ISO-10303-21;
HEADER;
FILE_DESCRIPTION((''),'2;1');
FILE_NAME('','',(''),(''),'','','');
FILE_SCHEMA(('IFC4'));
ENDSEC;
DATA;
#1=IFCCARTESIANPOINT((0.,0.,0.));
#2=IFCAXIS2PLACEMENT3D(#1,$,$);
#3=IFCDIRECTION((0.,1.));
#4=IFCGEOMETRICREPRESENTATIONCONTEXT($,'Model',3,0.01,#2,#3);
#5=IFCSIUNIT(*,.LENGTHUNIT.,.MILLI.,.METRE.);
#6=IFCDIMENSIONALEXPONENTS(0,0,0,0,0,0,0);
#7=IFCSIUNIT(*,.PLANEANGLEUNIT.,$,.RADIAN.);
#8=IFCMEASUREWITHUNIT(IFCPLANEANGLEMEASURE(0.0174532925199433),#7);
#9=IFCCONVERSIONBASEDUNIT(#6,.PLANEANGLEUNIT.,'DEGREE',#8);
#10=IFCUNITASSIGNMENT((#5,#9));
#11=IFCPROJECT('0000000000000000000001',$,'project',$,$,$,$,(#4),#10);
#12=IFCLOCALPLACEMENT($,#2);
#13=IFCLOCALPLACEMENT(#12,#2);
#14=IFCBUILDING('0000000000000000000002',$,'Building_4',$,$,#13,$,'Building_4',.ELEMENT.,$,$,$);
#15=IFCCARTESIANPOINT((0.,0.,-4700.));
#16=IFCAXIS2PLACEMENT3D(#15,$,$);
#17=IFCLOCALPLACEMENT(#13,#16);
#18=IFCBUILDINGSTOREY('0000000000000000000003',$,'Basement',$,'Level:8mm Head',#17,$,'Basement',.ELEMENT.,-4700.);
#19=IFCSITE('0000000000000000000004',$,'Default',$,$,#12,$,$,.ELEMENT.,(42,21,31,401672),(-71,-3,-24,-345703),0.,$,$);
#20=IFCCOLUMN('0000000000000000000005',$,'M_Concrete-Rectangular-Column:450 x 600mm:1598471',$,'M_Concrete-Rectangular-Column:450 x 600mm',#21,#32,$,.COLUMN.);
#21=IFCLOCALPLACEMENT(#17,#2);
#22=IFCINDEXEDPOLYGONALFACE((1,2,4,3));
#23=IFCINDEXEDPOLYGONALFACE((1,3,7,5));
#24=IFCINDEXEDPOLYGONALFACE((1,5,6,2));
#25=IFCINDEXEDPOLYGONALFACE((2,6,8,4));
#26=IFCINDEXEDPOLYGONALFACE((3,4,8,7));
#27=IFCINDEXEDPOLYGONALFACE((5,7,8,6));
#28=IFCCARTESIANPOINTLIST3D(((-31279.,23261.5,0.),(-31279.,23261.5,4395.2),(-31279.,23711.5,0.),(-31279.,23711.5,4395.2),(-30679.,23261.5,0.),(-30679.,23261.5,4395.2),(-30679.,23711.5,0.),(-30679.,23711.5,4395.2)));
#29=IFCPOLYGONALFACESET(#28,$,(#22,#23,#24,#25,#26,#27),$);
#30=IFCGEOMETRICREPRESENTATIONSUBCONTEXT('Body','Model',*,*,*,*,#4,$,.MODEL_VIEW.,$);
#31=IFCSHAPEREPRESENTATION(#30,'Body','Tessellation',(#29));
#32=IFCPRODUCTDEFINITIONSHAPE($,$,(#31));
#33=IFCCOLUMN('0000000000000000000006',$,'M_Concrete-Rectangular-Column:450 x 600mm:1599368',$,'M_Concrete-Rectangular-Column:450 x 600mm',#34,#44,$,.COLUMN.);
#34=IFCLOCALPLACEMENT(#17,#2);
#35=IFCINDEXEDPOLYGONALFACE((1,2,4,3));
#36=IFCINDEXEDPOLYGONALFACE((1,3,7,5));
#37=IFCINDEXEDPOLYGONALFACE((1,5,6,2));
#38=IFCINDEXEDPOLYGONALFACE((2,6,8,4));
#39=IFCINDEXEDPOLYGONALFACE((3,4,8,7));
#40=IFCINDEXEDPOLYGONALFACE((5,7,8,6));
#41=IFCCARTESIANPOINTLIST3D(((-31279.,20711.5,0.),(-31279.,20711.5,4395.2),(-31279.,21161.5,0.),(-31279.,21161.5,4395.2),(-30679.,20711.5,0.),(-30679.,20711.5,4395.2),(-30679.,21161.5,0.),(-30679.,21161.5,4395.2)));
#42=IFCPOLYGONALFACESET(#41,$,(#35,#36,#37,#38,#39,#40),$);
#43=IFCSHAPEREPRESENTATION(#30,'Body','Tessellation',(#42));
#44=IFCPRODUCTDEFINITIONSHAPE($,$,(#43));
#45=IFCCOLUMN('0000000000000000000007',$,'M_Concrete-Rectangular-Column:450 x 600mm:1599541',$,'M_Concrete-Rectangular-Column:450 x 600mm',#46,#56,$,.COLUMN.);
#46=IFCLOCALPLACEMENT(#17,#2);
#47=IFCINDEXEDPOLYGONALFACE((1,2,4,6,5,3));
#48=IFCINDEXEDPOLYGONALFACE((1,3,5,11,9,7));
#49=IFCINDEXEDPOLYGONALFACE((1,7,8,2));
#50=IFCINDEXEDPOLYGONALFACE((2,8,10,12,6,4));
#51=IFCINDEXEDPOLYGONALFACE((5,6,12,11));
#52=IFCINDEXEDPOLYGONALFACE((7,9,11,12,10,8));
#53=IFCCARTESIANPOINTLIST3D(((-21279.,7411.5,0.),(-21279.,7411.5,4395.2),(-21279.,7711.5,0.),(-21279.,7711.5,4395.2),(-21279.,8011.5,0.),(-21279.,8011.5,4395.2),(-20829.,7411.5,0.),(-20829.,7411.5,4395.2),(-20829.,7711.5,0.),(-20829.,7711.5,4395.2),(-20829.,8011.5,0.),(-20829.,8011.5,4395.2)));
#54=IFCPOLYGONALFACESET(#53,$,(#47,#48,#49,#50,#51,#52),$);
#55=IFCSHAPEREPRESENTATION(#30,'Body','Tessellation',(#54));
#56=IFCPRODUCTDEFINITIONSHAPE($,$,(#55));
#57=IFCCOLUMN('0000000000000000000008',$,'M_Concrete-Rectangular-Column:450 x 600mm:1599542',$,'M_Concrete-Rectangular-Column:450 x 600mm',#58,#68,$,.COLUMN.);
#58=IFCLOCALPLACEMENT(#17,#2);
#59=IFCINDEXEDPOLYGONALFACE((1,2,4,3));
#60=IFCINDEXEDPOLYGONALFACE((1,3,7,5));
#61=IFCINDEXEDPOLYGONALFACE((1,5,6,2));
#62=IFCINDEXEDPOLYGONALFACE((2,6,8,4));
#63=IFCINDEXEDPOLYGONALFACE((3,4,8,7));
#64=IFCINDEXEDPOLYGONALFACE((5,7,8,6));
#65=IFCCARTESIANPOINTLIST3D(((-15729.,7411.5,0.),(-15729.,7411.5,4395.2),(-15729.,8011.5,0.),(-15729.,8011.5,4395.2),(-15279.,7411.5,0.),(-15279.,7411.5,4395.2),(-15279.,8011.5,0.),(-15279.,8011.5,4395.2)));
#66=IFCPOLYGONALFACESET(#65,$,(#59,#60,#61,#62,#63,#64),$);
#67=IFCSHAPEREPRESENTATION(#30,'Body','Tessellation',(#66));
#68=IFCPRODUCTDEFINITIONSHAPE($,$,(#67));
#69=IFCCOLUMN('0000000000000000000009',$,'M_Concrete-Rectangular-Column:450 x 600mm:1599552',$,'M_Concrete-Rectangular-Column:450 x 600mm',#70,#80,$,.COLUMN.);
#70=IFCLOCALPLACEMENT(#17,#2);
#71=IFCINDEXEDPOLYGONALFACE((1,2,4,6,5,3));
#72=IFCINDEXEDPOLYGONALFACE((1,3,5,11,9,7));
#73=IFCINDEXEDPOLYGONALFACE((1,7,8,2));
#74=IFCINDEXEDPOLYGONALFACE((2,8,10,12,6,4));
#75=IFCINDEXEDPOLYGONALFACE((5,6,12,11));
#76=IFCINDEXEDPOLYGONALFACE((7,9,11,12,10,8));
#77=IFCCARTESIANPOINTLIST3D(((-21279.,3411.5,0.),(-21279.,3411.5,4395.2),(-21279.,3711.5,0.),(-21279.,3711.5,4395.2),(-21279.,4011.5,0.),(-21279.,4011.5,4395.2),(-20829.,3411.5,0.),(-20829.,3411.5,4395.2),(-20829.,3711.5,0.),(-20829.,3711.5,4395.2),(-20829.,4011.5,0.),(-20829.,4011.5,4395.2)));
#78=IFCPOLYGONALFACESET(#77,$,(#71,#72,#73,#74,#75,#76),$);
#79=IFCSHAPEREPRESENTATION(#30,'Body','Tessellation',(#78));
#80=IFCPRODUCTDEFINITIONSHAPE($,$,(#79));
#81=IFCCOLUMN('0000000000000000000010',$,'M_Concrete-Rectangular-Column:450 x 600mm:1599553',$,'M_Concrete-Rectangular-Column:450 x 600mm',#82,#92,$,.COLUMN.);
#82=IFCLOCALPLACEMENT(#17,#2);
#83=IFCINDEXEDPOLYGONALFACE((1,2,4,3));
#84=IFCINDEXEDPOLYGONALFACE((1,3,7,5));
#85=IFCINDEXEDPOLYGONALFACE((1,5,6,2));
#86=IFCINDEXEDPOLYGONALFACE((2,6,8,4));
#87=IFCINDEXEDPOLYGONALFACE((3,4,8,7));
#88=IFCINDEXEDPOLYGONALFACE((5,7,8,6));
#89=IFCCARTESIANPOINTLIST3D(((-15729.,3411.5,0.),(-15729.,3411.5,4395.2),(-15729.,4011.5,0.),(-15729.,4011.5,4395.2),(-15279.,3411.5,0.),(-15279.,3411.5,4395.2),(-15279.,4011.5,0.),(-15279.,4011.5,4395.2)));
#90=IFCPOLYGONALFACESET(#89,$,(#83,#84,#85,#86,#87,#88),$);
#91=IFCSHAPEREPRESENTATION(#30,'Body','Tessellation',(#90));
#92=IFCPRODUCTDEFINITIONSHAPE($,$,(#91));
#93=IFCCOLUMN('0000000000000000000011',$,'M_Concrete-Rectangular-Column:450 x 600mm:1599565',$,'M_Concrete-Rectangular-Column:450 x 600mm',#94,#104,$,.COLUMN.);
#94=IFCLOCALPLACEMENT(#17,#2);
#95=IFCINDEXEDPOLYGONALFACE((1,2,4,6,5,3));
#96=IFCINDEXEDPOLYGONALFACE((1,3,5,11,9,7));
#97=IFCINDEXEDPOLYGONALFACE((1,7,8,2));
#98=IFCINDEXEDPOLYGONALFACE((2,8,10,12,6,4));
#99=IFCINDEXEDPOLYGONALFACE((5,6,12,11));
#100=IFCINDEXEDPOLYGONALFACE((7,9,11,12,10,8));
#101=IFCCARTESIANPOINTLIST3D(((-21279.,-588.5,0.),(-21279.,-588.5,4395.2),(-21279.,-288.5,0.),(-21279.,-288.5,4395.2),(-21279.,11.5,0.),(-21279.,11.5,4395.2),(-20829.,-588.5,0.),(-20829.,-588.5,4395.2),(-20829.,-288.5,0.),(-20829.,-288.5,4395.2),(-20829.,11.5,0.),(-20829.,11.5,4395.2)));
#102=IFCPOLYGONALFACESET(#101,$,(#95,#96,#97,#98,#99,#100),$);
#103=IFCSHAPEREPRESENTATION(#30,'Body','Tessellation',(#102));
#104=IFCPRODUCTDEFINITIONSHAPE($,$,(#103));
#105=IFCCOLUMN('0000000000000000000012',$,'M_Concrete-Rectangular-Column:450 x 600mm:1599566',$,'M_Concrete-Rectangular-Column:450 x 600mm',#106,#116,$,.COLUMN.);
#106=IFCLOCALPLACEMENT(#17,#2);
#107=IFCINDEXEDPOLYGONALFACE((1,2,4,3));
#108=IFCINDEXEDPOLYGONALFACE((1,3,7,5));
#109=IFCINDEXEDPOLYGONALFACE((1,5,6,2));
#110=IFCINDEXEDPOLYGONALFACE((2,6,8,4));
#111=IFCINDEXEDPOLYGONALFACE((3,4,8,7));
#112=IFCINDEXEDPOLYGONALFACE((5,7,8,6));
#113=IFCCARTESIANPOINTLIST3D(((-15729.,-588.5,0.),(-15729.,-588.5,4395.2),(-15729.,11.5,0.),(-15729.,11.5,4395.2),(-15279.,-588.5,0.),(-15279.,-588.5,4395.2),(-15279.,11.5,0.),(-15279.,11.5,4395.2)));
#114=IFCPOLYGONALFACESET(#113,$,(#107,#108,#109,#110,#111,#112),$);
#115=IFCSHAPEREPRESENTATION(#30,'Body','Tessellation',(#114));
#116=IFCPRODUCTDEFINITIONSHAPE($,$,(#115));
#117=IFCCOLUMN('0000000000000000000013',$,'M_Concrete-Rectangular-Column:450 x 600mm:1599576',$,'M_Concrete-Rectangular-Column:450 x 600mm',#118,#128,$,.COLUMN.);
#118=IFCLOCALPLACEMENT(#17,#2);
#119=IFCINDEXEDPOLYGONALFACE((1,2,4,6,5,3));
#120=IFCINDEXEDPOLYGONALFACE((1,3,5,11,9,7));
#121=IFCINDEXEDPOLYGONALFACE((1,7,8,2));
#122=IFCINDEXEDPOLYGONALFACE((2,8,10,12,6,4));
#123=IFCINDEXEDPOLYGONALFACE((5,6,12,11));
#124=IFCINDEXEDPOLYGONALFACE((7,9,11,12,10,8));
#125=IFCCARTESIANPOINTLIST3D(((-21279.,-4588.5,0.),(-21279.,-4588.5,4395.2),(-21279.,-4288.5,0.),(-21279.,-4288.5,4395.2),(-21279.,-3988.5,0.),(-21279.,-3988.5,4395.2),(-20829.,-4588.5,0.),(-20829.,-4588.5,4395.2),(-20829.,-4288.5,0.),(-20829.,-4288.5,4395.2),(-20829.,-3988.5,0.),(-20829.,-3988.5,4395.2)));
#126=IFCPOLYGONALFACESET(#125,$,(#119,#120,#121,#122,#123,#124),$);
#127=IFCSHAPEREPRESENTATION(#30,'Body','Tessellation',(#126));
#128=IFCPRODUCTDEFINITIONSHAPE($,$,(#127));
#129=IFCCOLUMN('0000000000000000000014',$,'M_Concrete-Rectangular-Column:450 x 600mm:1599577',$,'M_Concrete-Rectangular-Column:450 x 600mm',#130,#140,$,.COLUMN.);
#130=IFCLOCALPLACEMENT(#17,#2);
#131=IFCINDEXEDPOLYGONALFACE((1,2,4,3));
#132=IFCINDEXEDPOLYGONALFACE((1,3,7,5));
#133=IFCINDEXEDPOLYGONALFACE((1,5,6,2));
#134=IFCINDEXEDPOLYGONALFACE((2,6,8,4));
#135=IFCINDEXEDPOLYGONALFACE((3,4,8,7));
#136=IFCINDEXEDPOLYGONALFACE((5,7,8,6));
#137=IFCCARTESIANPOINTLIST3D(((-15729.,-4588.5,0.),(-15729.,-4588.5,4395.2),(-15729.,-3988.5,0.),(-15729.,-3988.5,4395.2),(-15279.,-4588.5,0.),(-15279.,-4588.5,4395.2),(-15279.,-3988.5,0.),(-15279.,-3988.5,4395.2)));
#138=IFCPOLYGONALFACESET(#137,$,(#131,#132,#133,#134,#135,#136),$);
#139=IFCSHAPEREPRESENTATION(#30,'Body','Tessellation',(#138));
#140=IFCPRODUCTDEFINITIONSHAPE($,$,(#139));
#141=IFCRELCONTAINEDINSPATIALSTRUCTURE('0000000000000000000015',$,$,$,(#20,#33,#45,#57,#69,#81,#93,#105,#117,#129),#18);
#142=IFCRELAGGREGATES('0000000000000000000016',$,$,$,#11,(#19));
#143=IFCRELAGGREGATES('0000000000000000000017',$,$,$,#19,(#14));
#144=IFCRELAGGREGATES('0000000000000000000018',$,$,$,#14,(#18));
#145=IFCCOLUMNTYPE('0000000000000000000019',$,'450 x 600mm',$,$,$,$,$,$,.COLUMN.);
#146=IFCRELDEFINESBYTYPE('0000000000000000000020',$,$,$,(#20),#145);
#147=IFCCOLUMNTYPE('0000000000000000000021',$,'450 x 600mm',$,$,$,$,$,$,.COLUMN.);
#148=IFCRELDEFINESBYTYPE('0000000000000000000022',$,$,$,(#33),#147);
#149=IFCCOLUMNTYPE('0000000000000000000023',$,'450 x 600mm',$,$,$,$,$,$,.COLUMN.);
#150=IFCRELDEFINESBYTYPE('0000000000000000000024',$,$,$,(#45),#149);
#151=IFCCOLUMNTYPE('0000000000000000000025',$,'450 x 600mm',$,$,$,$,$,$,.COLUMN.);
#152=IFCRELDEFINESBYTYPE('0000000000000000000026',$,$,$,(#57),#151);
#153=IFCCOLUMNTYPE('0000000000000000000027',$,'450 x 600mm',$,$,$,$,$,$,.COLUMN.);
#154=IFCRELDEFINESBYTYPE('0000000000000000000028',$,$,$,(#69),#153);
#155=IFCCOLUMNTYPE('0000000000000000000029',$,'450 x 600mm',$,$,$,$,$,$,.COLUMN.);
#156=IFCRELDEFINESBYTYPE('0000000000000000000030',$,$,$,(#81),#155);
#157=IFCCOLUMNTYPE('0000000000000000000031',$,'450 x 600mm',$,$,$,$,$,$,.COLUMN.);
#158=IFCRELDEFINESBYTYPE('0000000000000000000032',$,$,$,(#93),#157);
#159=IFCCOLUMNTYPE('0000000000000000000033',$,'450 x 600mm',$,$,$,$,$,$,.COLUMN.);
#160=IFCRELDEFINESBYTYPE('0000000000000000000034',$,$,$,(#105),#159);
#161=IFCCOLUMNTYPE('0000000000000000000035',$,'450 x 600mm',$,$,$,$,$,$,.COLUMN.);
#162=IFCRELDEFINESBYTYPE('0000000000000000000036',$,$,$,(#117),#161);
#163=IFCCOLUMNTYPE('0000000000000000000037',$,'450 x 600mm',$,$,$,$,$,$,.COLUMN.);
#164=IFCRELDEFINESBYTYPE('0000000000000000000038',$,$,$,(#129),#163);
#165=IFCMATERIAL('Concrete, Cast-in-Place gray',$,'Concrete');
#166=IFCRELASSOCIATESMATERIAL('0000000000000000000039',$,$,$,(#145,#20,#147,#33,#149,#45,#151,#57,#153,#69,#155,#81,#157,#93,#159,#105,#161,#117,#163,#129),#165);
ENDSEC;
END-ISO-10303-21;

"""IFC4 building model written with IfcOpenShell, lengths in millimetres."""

from ifc_helpers import new_model, entity, si_unit, converted_unit, direction, frame, origin, place, context, subcontext, project, spatial, indexed_curve, outline, extrude, source, transform, mapped, material, type_object, type_shapes, element, save


model = new_model("IFC4")

# Units and contexts
model_context = context("Model", 3, precision=0.01, world=origin(), true_north=direction((0.0, 1.0)))
body_context = subcontext(model_context, "Body", "Model", "MODEL_VIEW")
ifc_project = project(units=[si_unit("LENGTHUNIT", "METRE", prefix="MILLI"), converted_unit("PLANEANGLEUNIT", "DEGREE", entity("IfcPlaneAngleMeasure", 0.0174532925199433), si_unit("PLANEANGLEUNIT", "RADIAN"), dimensions=[0, 0, 0, 0, 0, 0, 0])], contexts=[model_context])

# Site, building, storey
site_placement = place(None, origin())
site = spatial("IfcSite", under=ifc_project, at=site_placement, Name="Default", CompositionType="ELEMENT", RefLatitude=(42, 21, 31, 401672), RefLongitude=(-71, -3, -24, -345703), RefElevation=0.0)
building_placement = place(site_placement, origin())
building = spatial("IfcBuilding", under=site, at=building_placement, Name="Building_4", LongName="Building_4", CompositionType="ELEMENT")
storey_placement = place(building_placement, frame((0.0, 0.0, -4700.0)))
storey = spatial("IfcBuildingStorey", under=building, at=storey_placement, Name="Basement", ObjectType="Level:8mm Head", LongName="Basement", CompositionType="ELEMENT", Elevation=-4700.0)

# Shared definitions
ifc_material_1 = material(Name="Concrete, Cast-in-Place gray", Category="Concrete")

# Columns
column_type_1 = type_object("IfcColumnType", Name="450 x 600mm", PredefinedType="COLUMN", material=ifc_material_1)
shared_shape_1 = source(origin(), body_context, "Body", "SweptSolid", [
    extrude(outline(indexed_curve([(-225.0, -300.0), (225.0, -300.0), (225.0, 300.0), (-225.0, 300.0), (-225.0, -300.0)], self_intersect=False)), frame((-30979.0, 23486.5, -4700.0), z_axis=(0.0, 0.0, 1.0), x_axis=(0.0, 1.0, 0.0)), (0.0, 0.0, 1.0), 4395.2),
])
type_shapes(column_type_1, [shared_shape_1])
column_1_placement = place(storey_placement, frame((0.0, 0.0, 4700.0)))
element("IfcColumn", 1, at=column_1_placement, inside=storey, type_object=column_type_1, material=ifc_material_1, Name="M_Concrete-Rectangular-Column:450 x 600mm:1598471", ObjectType="M_Concrete-Rectangular-Column:450 x 600mm", PredefinedType="COLUMN", context=body_context, shape_type="MappedRepresentation", body=[
    mapped(shared_shape_1, transform((0.0, 0.0, 0.0), scale=1.0)),
])
column_type_2 = type_object("IfcColumnType", Name="450 x 600mm", PredefinedType="COLUMN", material=ifc_material_1)
shared_shape_2 = source(origin(), body_context, "Body", "SweptSolid", [
    extrude(outline(indexed_curve([(-300.0, -225.0), (300.0, -225.0), (300.0, 225.0), (-300.0, 225.0), (-300.0, -225.0)], self_intersect=False)), frame((-30979.0, 20936.5, -4700.0), z_axis=(0.0, 0.0, 1.0), x_axis=(-1.0, 0.0, 0.0)), (0.0, 0.0, 1.0), 4395.2),
])
type_shapes(column_type_2, [shared_shape_2])
column_2_placement = place(storey_placement, frame((0.0, 0.0, 4700.0)))
element("IfcColumn", 2, at=column_2_placement, inside=storey, type_object=column_type_2, material=ifc_material_1, Name="M_Concrete-Rectangular-Column:450 x 600mm:1599368", ObjectType="M_Concrete-Rectangular-Column:450 x 600mm", PredefinedType="COLUMN", context=body_context, shape_type="MappedRepresentation", body=[
    mapped(shared_shape_2, transform((0.0, 0.0, 0.0), scale=1.0)),
])
column_type_3 = type_object("IfcColumnType", Name="450 x 600mm", PredefinedType="COLUMN", material=ifc_material_1)
shared_shape_3 = source(origin(), body_context, "Body", "SweptSolid", [
    extrude(outline(indexed_curve([(-2197.6, -300.0), (2197.6, -300.0), (2197.6, 0.0), (2197.6, 300.0), (-2197.6, 300.0), (-2197.6, 0.0), (-2197.6, -300.0)], self_intersect=False)), frame((-21279.0, 7711.5, -2502.4), z_axis=(1.0, 0.0, 0.0), x_axis=(0.0, 0.0, 1.0)), (0.0, 0.0, 1.0), 450.0),
])
type_shapes(column_type_3, [shared_shape_3])
column_3_placement = place(storey_placement, frame((0.0, 0.0, 4700.0)))
element("IfcColumn", 3, at=column_3_placement, inside=storey, type_object=column_type_3, material=ifc_material_1, Name="M_Concrete-Rectangular-Column:450 x 600mm:1599541", ObjectType="M_Concrete-Rectangular-Column:450 x 600mm", PredefinedType="COLUMN", context=body_context, shape_type="MappedRepresentation", body=[
    mapped(shared_shape_3, transform((0.0, 0.0, 0.0), scale=1.0)),
])
column_type_4 = type_object("IfcColumnType", Name="450 x 600mm", PredefinedType="COLUMN", material=ifc_material_1)
shared_shape_4 = source(origin(), body_context, "Body", "SweptSolid", [
    extrude(outline(indexed_curve([(-2197.6, -300.0), (2197.6, -300.0), (2197.6, 300.0), (-2197.6, 300.0), (-2197.6, -300.0)], self_intersect=False)), frame((-15729.0, 7711.5, -2502.4), z_axis=(1.0, 0.0, 0.0), x_axis=(0.0, 0.0, 1.0)), (0.0, 0.0, 1.0), 450.0),
])
type_shapes(column_type_4, [shared_shape_4])
column_4_placement = place(storey_placement, frame((0.0, 0.0, 4700.0)))
element("IfcColumn", 4, at=column_4_placement, inside=storey, type_object=column_type_4, material=ifc_material_1, Name="M_Concrete-Rectangular-Column:450 x 600mm:1599542", ObjectType="M_Concrete-Rectangular-Column:450 x 600mm", PredefinedType="COLUMN", context=body_context, shape_type="MappedRepresentation", body=[
    mapped(shared_shape_4, transform((0.0, 0.0, 0.0), scale=1.0)),
])
column_type_5 = type_object("IfcColumnType", Name="450 x 600mm", PredefinedType="COLUMN", material=ifc_material_1)
shared_shape_5 = source(origin(), body_context, "Body", "SweptSolid", [
    extrude(outline(indexed_curve([(-2197.6, -300.0), (2197.6, -300.0), (2197.6, 0.0), (2197.6, 300.0), (-2197.6, 300.0), (-2197.6, 0.0), (-2197.6, -300.0)], self_intersect=False)), frame((-21279.0, 3711.5, -2502.4), z_axis=(1.0, 0.0, 0.0), x_axis=(0.0, 0.0, 1.0)), (0.0, 0.0, 1.0), 450.0),
])
type_shapes(column_type_5, [shared_shape_5])
column_5_placement = place(storey_placement, frame((0.0, 0.0, 4700.0)))
element("IfcColumn", 5, at=column_5_placement, inside=storey, type_object=column_type_5, material=ifc_material_1, Name="M_Concrete-Rectangular-Column:450 x 600mm:1599552", ObjectType="M_Concrete-Rectangular-Column:450 x 600mm", PredefinedType="COLUMN", context=body_context, shape_type="MappedRepresentation", body=[
    mapped(shared_shape_5, transform((0.0, 0.0, 0.0), scale=1.0)),
])
column_type_6 = type_object("IfcColumnType", Name="450 x 600mm", PredefinedType="COLUMN", material=ifc_material_1)
shared_shape_6 = source(origin(), body_context, "Body", "SweptSolid", [
    extrude(outline(indexed_curve([(-2197.6, -300.0), (2197.6, -300.0), (2197.6, 300.0), (-2197.6, 300.0), (-2197.6, -300.0)], self_intersect=False)), frame((-15729.0, 3711.5, -2502.4), z_axis=(1.0, 0.0, 0.0), x_axis=(0.0, 0.0, 1.0)), (0.0, 0.0, 1.0), 450.0),
])
type_shapes(column_type_6, [shared_shape_6])
column_6_placement = place(storey_placement, frame((0.0, 0.0, 4700.0)))
element("IfcColumn", 6, at=column_6_placement, inside=storey, type_object=column_type_6, material=ifc_material_1, Name="M_Concrete-Rectangular-Column:450 x 600mm:1599553", ObjectType="M_Concrete-Rectangular-Column:450 x 600mm", PredefinedType="COLUMN", context=body_context, shape_type="MappedRepresentation", body=[
    mapped(shared_shape_6, transform((0.0, 0.0, 0.0), scale=1.0)),
])
column_type_7 = type_object("IfcColumnType", Name="450 x 600mm", PredefinedType="COLUMN", material=ifc_material_1)
shared_shape_7 = source(origin(), body_context, "Body", "SweptSolid", [
    extrude(outline(indexed_curve([(-2197.6, -300.0), (2197.6, -300.0), (2197.6, 0.0), (2197.6, 300.0), (-2197.6, 300.0), (-2197.6, 0.0), (-2197.6, -300.0)], self_intersect=False)), frame((-21279.0, -288.5, -2502.4), z_axis=(1.0, 0.0, 0.0), x_axis=(0.0, 0.0, 1.0)), (0.0, 0.0, 1.0), 450.0),
])
type_shapes(column_type_7, [shared_shape_7])
column_7_placement = place(storey_placement, frame((0.0, 0.0, 4700.0)))
element("IfcColumn", 7, at=column_7_placement, inside=storey, type_object=column_type_7, material=ifc_material_1, Name="M_Concrete-Rectangular-Column:450 x 600mm:1599565", ObjectType="M_Concrete-Rectangular-Column:450 x 600mm", PredefinedType="COLUMN", context=body_context, shape_type="MappedRepresentation", body=[
    mapped(shared_shape_7, transform((0.0, 0.0, 0.0), scale=1.0)),
])
column_type_8 = type_object("IfcColumnType", Name="450 x 600mm", PredefinedType="COLUMN", material=ifc_material_1)
shared_shape_8 = source(origin(), body_context, "Body", "SweptSolid", [
    extrude(outline(indexed_curve([(-2197.6, -300.0), (2197.6, -300.0), (2197.6, 300.0), (-2197.6, 300.0), (-2197.6, -300.0)], self_intersect=False)), frame((-15729.0, -288.5, -2502.4), z_axis=(1.0, 0.0, 0.0), x_axis=(0.0, 0.0, 1.0)), (0.0, 0.0, 1.0), 450.0),
])
type_shapes(column_type_8, [shared_shape_8])
column_8_placement = place(storey_placement, frame((0.0, 0.0, 4700.0)))
element("IfcColumn", 8, at=column_8_placement, inside=storey, type_object=column_type_8, material=ifc_material_1, Name="M_Concrete-Rectangular-Column:450 x 600mm:1599566", ObjectType="M_Concrete-Rectangular-Column:450 x 600mm", PredefinedType="COLUMN", context=body_context, shape_type="MappedRepresentation", body=[
    mapped(shared_shape_8, transform((0.0, 0.0, 0.0), scale=1.0)),
])
column_type_9 = type_object("IfcColumnType", Name="450 x 600mm", PredefinedType="COLUMN", material=ifc_material_1)
shared_shape_9 = source(origin(), body_context, "Body", "SweptSolid", [
    extrude(outline(indexed_curve([(-2197.6, -300.0), (2197.6, -300.0), (2197.6, 0.0), (2197.6, 300.0), (-2197.6, 300.0), (-2197.6, 0.0), (-2197.6, -300.0)], self_intersect=False)), frame((-21279.0, -4288.5, -2502.4), z_axis=(1.0, 0.0, 0.0), x_axis=(0.0, 0.0, 1.0)), (0.0, 0.0, 1.0), 450.0),
])
type_shapes(column_type_9, [shared_shape_9])
column_9_placement = place(storey_placement, frame((0.0, 0.0, 4700.0)))
element("IfcColumn", 9, at=column_9_placement, inside=storey, type_object=column_type_9, material=ifc_material_1, Name="M_Concrete-Rectangular-Column:450 x 600mm:1599576", ObjectType="M_Concrete-Rectangular-Column:450 x 600mm", PredefinedType="COLUMN", context=body_context, shape_type="MappedRepresentation", body=[
    mapped(shared_shape_9, transform((0.0, 0.0, 0.0), scale=1.0)),
])
column_type_10 = type_object("IfcColumnType", Name="450 x 600mm", PredefinedType="COLUMN", material=ifc_material_1)
shared_shape_10 = source(origin(), body_context, "Body", "SweptSolid", [
    extrude(outline(indexed_curve([(-2197.6, -300.0), (2197.6, -300.0), (2197.6, 300.0), (-2197.6, 300.0), (-2197.6, -300.0)], self_intersect=False)), frame((-15729.0, -4288.5, -2502.4), z_axis=(1.0, 0.0, 0.0), x_axis=(0.0, 0.0, 1.0)), (0.0, 0.0, 1.0), 450.0),
])
type_shapes(column_type_10, [shared_shape_10])
column_10_placement = place(storey_placement, frame((0.0, 0.0, 4700.0)))
element("IfcColumn", 10, at=column_10_placement, inside=storey, type_object=column_type_10, material=ifc_material_1, Name="M_Concrete-Rectangular-Column:450 x 600mm:1599577", ObjectType="M_Concrete-Rectangular-Column:450 x 600mm", PredefinedType="COLUMN", context=body_context, shape_type="MappedRepresentation", body=[
    mapped(shared_shape_10, transform((0.0, 0.0, 0.0), scale=1.0)),
])

save(model, "model.ifc")
